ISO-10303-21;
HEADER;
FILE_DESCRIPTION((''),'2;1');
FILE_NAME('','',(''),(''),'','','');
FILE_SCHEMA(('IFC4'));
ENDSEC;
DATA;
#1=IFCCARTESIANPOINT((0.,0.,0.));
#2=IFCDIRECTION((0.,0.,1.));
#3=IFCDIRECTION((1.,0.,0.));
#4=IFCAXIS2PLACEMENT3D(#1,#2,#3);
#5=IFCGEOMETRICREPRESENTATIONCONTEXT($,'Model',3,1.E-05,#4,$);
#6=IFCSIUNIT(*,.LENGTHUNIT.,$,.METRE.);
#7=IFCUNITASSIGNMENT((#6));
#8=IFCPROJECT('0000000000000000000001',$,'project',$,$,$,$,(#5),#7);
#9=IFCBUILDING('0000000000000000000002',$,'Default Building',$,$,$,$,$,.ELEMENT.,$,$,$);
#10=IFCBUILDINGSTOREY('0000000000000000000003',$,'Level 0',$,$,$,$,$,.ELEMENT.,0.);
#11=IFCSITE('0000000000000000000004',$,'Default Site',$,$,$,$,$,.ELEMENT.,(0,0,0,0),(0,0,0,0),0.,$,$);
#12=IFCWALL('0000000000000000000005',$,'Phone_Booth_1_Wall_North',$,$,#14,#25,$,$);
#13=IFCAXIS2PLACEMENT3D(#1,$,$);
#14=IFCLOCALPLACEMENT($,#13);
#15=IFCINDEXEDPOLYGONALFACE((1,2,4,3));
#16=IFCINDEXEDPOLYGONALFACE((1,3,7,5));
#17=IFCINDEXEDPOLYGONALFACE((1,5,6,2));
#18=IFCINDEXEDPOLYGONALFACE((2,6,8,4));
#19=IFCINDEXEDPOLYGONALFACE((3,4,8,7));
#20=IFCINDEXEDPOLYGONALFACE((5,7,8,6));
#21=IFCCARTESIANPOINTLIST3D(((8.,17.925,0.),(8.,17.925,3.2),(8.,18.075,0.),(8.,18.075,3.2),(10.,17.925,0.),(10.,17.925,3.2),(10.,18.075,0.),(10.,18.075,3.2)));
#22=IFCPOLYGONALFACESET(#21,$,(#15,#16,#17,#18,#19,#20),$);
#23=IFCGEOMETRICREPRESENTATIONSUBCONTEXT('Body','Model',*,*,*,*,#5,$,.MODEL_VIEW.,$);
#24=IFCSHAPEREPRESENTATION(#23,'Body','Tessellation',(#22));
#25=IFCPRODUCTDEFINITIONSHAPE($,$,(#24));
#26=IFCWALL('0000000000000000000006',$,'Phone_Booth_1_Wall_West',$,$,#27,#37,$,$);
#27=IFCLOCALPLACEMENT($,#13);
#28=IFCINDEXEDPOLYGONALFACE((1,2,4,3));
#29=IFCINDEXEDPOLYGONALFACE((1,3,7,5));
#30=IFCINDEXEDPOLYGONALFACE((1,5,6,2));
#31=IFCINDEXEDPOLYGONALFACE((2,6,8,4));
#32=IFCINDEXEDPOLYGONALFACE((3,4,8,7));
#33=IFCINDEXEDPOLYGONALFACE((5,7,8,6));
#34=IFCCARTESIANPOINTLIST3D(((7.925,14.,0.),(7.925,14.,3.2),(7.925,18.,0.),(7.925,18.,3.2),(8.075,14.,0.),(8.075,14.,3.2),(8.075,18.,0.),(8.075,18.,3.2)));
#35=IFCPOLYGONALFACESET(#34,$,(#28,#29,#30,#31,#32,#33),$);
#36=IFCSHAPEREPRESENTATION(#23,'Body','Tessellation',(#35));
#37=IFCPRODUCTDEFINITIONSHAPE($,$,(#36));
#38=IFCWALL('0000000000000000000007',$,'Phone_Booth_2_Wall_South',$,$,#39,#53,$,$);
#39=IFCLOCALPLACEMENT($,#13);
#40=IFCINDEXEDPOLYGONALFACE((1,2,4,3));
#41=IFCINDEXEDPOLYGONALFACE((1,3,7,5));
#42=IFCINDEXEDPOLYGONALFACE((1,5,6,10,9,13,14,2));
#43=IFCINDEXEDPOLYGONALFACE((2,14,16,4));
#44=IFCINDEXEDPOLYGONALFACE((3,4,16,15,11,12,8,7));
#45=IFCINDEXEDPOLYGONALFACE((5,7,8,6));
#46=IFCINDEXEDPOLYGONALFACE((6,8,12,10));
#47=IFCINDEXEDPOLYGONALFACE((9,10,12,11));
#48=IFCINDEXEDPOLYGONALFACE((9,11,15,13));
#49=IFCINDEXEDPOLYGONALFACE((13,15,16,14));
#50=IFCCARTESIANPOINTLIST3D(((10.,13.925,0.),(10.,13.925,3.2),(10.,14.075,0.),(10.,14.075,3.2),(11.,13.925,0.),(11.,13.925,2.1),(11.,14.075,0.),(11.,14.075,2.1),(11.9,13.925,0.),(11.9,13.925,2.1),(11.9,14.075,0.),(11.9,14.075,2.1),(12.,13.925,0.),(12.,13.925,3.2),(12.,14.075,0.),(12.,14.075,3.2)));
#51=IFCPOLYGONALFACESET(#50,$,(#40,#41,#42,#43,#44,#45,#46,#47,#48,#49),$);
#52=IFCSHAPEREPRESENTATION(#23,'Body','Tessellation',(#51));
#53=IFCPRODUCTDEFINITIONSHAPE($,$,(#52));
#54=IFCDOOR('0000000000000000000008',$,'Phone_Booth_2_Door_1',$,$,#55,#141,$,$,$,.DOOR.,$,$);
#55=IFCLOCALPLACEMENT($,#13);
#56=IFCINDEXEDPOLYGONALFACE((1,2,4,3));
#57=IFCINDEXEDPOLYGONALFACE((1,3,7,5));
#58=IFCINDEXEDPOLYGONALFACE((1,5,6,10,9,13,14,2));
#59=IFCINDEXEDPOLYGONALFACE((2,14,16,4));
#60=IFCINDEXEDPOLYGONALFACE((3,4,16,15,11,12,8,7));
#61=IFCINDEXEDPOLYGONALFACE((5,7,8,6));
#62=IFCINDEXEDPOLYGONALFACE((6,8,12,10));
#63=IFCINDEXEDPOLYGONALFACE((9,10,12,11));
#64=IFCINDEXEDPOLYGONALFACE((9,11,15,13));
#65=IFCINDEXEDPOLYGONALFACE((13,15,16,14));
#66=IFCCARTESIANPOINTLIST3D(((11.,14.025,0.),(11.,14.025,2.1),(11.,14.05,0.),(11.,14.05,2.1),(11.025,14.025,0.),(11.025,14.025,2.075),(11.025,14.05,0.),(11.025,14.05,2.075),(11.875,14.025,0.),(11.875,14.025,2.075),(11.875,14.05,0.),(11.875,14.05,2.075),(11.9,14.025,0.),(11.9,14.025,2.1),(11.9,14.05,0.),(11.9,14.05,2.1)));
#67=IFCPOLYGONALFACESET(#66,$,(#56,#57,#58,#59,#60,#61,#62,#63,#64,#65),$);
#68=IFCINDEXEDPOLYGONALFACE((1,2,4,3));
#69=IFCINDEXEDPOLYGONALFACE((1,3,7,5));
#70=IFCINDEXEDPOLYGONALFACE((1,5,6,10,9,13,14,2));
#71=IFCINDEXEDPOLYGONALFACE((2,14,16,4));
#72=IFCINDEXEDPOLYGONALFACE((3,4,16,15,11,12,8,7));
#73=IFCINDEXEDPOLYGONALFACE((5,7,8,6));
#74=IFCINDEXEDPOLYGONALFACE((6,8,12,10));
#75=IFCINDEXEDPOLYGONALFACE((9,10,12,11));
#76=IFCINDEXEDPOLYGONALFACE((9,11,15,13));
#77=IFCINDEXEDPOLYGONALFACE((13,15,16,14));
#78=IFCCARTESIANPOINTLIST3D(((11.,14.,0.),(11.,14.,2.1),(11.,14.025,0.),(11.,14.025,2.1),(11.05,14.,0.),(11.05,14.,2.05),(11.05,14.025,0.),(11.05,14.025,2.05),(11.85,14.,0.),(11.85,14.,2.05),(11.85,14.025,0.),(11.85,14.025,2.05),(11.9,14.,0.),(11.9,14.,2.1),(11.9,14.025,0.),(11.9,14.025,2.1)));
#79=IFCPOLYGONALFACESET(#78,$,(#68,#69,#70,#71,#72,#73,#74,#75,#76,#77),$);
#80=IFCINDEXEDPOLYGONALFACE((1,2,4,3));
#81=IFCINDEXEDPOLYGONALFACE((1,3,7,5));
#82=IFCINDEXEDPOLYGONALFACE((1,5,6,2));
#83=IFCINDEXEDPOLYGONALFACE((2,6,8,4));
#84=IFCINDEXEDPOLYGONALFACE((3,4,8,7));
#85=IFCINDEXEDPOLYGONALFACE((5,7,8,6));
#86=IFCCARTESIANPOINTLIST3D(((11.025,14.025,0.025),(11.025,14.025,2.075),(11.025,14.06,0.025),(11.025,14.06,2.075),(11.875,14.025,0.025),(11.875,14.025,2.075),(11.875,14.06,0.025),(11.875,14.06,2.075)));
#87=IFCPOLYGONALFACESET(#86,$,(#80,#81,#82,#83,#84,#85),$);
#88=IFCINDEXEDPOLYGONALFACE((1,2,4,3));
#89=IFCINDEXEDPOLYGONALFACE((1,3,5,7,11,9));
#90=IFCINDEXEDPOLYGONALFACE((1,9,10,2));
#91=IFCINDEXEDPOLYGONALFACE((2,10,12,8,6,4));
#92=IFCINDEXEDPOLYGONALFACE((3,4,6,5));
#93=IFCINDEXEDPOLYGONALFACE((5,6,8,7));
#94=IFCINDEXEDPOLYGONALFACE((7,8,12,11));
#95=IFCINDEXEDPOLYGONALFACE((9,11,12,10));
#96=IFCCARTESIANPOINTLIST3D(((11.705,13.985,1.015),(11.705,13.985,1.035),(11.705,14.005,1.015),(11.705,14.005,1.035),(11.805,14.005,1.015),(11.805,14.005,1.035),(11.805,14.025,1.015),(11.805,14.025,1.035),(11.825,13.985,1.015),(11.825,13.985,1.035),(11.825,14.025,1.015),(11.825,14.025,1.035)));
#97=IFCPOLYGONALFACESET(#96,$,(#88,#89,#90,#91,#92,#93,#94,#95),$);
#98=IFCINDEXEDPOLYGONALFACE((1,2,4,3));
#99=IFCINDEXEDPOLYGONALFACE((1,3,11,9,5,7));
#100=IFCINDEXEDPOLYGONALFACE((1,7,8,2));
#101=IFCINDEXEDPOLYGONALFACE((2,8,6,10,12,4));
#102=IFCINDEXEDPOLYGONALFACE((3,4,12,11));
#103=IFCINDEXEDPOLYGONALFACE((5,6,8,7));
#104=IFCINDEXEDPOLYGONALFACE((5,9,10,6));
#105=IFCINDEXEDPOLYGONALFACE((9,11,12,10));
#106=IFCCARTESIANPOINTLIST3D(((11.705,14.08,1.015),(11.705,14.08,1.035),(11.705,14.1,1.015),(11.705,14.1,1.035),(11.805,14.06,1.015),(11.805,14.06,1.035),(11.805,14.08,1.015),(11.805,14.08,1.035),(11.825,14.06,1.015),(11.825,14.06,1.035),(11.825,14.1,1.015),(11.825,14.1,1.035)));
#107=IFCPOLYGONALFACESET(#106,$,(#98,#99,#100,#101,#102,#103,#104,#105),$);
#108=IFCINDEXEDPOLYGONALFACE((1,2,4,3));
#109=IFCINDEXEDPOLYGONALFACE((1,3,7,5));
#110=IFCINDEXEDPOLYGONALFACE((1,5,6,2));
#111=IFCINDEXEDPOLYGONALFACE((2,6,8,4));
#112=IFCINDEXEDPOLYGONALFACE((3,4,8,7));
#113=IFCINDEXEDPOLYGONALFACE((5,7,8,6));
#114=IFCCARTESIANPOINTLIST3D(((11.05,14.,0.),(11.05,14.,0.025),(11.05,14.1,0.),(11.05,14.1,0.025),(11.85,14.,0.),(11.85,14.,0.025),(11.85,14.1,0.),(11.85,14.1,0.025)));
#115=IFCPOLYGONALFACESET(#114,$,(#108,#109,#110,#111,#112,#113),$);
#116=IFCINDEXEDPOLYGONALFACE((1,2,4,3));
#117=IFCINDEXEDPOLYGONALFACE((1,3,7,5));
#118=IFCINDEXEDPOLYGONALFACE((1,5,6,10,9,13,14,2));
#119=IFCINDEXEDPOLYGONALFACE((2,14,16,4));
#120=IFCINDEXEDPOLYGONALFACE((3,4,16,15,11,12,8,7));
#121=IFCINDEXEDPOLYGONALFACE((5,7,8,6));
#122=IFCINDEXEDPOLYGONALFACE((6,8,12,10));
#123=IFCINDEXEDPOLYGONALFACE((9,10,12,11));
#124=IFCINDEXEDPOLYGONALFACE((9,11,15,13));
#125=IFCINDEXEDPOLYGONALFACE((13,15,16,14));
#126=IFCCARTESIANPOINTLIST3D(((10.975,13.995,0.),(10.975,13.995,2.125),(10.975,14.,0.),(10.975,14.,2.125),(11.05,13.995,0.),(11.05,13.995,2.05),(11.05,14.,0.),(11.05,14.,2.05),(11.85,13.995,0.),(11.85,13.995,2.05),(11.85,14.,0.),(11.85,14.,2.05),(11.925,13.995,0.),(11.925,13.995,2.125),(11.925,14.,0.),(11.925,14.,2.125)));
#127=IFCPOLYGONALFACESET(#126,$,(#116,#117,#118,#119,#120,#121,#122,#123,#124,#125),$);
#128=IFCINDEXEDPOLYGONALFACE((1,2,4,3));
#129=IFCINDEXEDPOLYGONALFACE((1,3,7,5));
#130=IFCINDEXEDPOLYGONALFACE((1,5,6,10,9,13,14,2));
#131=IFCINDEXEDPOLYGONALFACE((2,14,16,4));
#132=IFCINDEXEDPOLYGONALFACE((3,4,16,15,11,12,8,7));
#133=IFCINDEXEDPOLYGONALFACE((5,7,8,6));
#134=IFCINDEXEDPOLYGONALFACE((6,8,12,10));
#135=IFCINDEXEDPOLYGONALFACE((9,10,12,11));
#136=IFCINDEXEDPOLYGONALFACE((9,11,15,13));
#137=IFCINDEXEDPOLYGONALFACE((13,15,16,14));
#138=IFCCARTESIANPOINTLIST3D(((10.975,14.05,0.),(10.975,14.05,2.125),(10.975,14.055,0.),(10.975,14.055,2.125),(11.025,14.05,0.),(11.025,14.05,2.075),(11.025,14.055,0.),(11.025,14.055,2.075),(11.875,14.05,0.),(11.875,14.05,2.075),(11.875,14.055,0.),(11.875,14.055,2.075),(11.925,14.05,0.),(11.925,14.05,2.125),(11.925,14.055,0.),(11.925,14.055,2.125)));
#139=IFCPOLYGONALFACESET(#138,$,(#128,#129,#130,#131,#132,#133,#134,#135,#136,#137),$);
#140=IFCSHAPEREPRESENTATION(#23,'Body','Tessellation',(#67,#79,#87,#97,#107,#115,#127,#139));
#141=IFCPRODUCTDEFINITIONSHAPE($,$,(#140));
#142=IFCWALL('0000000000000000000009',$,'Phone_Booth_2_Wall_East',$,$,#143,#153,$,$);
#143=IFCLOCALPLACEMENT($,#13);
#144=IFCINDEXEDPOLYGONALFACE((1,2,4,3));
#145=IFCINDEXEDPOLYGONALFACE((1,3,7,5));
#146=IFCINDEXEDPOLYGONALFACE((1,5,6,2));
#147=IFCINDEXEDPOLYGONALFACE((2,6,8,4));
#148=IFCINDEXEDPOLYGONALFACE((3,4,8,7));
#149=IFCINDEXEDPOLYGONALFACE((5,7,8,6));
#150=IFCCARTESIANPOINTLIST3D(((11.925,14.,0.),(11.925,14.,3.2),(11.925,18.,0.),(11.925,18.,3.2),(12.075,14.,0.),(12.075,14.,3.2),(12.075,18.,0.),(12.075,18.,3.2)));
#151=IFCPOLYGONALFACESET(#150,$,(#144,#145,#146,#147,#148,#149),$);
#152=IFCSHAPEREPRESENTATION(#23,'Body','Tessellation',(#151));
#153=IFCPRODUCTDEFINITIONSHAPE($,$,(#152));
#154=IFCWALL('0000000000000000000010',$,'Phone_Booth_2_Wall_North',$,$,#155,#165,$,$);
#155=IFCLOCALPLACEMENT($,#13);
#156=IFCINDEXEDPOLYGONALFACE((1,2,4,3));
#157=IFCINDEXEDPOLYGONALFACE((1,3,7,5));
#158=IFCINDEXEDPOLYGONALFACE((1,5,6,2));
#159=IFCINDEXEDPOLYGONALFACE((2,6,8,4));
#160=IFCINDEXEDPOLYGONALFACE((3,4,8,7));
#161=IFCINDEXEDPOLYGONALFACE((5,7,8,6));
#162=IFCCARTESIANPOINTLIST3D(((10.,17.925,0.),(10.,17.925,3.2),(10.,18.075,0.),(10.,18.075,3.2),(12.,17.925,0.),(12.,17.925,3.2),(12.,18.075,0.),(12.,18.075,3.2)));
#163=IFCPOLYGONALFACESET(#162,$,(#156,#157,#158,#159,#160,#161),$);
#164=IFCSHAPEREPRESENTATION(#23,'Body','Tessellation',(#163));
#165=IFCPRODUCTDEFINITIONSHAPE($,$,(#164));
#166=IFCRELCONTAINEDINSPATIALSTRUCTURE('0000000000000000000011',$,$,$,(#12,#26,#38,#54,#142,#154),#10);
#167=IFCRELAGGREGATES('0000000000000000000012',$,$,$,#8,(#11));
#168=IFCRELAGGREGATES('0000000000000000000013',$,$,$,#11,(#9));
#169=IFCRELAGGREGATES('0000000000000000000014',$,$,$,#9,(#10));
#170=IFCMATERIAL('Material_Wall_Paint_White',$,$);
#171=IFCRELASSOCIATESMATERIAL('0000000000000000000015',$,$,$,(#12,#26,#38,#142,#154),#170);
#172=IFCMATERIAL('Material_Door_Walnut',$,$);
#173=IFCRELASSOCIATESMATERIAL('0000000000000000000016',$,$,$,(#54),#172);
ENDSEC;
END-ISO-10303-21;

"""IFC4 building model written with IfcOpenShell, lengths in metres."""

from ifc_helpers import new_model, si_unit, frame, origin_with_axes, place, context, subcontext, project, spatial, line, indexed_curve, outline, extrude, material, element, fill, save


model = new_model("IFC4")

# Units and contexts
model_context = context("Model", 3, precision=1e-05, world=origin_with_axes())
body_context = subcontext(model_context, "Body", "Model", "MODEL_VIEW")
ifc_project = project(units=[si_unit("LENGTHUNIT", "METRE")], contexts=[model_context])

# Site, building, storey
site = spatial("IfcSite", under=ifc_project, Name="Default Site", CompositionType="ELEMENT", RefLatitude=(0, 0, 0, 0), RefLongitude=(0, 0, 0, 0), RefElevation=0.0)
building = spatial("IfcBuilding", under=site, Name="Default Building", CompositionType="ELEMENT")
storey = spatial("IfcBuildingStorey", under=building, Name="Level 0", CompositionType="ELEMENT", Elevation=0.0)

# Shared definitions
ifc_material_1 = material(Name="Material_Wall_Paint_White")

# Shared definitions
ifc_material_2 = material(Name="Material_Door_Walnut")

# Walls
wall_1_placement = place(None, frame((10.0, 18.0, 0.0), z_axis=(0.0, 0.0, 1.0), x_axis=(-1.0, 0.0, 0.0)))
element("IfcWall", 1, at=wall_1_placement, inside=storey, material=ifc_material_1, Name="Phone_Booth_1_Wall_North", context=body_context, shape_type="SweptSolid", body=[
    extrude(outline(indexed_curve([(0.0, 0.0), (0.0, 0.15), (2.0, 0.15), (2.0, 0.0), (0.0, 0.0)], self_intersect=False)), frame((0.0, -0.075, 0.0), z_axis=(0.0, 0.0, 1.0), x_axis=(1.0, 0.0, 0.0)), (0.0, 0.0, 1.0), 3.2),
])
wall_2_placement = place(None, frame((8.0, 18.0, 0.0), z_axis=(0.0, 0.0, 1.0), x_axis=(0.0, -1.0, 0.0)))
element("IfcWall", 2, at=wall_2_placement, inside=storey, material=ifc_material_1, Name="Phone_Booth_1_Wall_West", context=body_context, shape_type="SweptSolid", body=[
    extrude(outline(indexed_curve([(0.0, 0.0), (0.0, 0.15), (4.0, 0.15), (4.0, 0.0), (0.0, 0.0)], self_intersect=False)), frame((0.0, -0.075, 0.0), z_axis=(0.0, 0.0, 1.0), x_axis=(1.0, 0.0, 0.0)), (0.0, 0.0, 1.0), 3.2),
])

# Wall, opening, door
wall_3_placement = place(None, frame((10.0, 14.0, 0.0), z_axis=(0.0, 0.0, 1.0), x_axis=(1.0, 0.0, 0.0)))
wall_3 = element("IfcWall", 3, at=wall_3_placement, inside=storey, material=ifc_material_1, Name="Phone_Booth_2_Wall_South", context=body_context, shape_type="SweptSolid", body=[
    extrude(outline(indexed_curve([(0.0, 0.0), (0.0, 0.15), (2.0, 0.15), (2.0, 0.0), (0.0, 0.0)], self_intersect=False)), frame((0.0, -0.075, 0.0), z_axis=(0.0, 0.0, 1.0), x_axis=(1.0, 0.0, 0.0)), (0.0, 0.0, 1.0), 3.2),
])
opening_1_placement = place(wall_3_placement, frame((1.0, -0.5, 0.0), z_axis=(0.0, 0.0, 1.0), x_axis=(1.0, 0.0, 0.0)))
opening_1 = element("IfcOpeningElement", 4, at=opening_1_placement, inside=storey, cuts=wall_3, PredefinedType="OPENING", context=body_context, shape_type="SweptSolid", body=[
    extrude(outline(indexed_curve([(0.0, 0.0), (0.0, 1.0), (0.9, 1.0), (0.9, 0.0), (0.0, 0.0)], self_intersect=False)), origin_with_axes(), (0.0, 0.0, 1.0), 2.1),
])
door_1_placement = place(None, frame((11.0, 14.0, 0.0), z_axis=(0.0, 0.0, 1.0), x_axis=(1.0, 0.0, 0.0)))
door_1 = element("IfcDoor", 5, at=door_1_placement, inside=storey, material=ifc_material_2, Name="Phone_Booth_2_Door_1", PredefinedType="DOOR", context=body_context, shape_type="SweptSolid", body=[
    extrude(outline(indexed_curve([(0.0, 0.0), (0.0, 2.1), (0.9, 2.1), (0.9, 0.0), (0.875, 0.0), (0.875, 2.075), (0.025, 2.075), (0.025, 0.0)], segments=[line(1, 2, 3, 4, 5, 6, 7, 8, 1)])), frame((0.0, 0.025, 0.0), z_axis=(0.0, -1.0, 0.0), x_axis=(1.0, 0.0, 0.0)), (0.0, 0.0, -1.0), 0.025),
    extrude(outline(indexed_curve([(0.0, 0.0), (0.0, 2.1), (0.9, 2.1), (0.9, 0.0), (0.85, 0.0), (0.85, 2.05), (0.05, 2.05), (0.05, 0.0)], segments=[line(1, 2, 3, 4, 5, 6, 7, 8, 1)])), frame((0.0, 0.0, 0.0), z_axis=(0.0, -1.0, 0.0), x_axis=(1.0, 0.0, 0.0)), (0.0, 0.0, -1.0), 0.025),
    extrude(outline(indexed_curve([(0.0, 0.0), (0.85, 0.0), (0.85, 0.035), (0.0, 0.035)], segments=[line(1, 2, 3, 4, 1)])), frame((0.025, 0.025, 0.025), z_axis=(0.0, 0.0, 1.0), x_axis=(1.0, 0.0, 0.0)), (0.0, 0.0, 1.0), 2.05),
    extrude(outline(indexed_curve([(0.0, 0.0), (0.0, -0.04), (-0.12, -0.04), (-0.12, -0.02), (-0.02, -0.02), (-0.02, 0.0)], segments=[line(1, 2, 3, 4, 5, 6, 1)])), frame((0.825, 0.025, 1.015), z_axis=(0.0, 0.0, 1.0), x_axis=(1.0, 0.0, 0.0)), (0.0, 0.0, 1.0), 0.02),
    extrude(outline(indexed_curve([(0.0, 0.0), (0.0, 0.04), (-0.12, 0.04), (-0.12, 0.02), (-0.02, 0.02), (-0.02, 0.0)], segments=[line(1, 2, 3, 4, 5, 6, 1)])), frame((0.825, 0.06, 1.015), z_axis=(0.0, 0.0, 1.0), x_axis=(1.0, 0.0, 0.0)), (0.0, 0.0, 1.0), 0.02),
    extrude(outline(indexed_curve([(0.0, 0.0), (0.8, 0.0), (0.8, 0.1), (0.0, 0.1)], segments=[line(1, 2, 3, 4, 1)])), frame((0.05, 0.0, 0.0), z_axis=(0.0, 0.0, 1.0), x_axis=(1.0, 0.0, 0.0)), (0.0, 0.0, 1.0), 0.025),
    extrude(outline(indexed_curve([(0.0, 0.0), (0.0, 2.125), (0.95, 2.125), (0.95, 0.0), (0.875, 0.0), (0.875, 2.05), (0.075, 2.05), (0.075, 0.0)], segments=[line(1, 2, 3, 4, 5, 6, 7, 8, 1)])), frame((-0.025, -0.005, 0.0), z_axis=(0.0, -1.0, 0.0), x_axis=(1.0, 0.0, 0.0)), (0.0, 0.0, -1.0), 0.005),
    extrude(outline(indexed_curve([(0.0, 0.0), (0.0, 2.125), (0.95, 2.125), (0.95, 0.0), (0.9, 0.0), (0.9, 2.075), (0.05, 2.075), (0.05, 0.0)], segments=[line(1, 2, 3, 4, 5, 6, 7, 8, 1)])), frame((-0.025, 0.05, 0.0), z_axis=(0.0, -1.0, 0.0), x_axis=(1.0, 0.0, 0.0)), (0.0, 0.0, -1.0), 0.005),
])
fill(opening_1, door_1)

# Walls
wall_4_placement = place(None, frame((12.0, 14.0, 0.0), z_axis=(0.0, 0.0, 1.0), x_axis=(0.0, 1.0, 0.0)))
element("IfcWall", 6, at=wall_4_placement, inside=storey, material=ifc_material_1, Name="Phone_Booth_2_Wall_East", context=body_context, shape_type="SweptSolid", body=[
    extrude(outline(indexed_curve([(0.0, 0.0), (0.0, 0.15), (4.0, 0.15), (4.0, 0.0), (0.0, 0.0)], self_intersect=False)), frame((0.0, -0.075, 0.0), z_axis=(0.0, 0.0, 1.0), x_axis=(1.0, 0.0, 0.0)), (0.0, 0.0, 1.0), 3.2),
])
wall_5_placement = place(None, frame((12.0, 18.0, 0.0), z_axis=(0.0, 0.0, 1.0), x_axis=(-1.0, 0.0, 0.0)))
element("IfcWall", 7, at=wall_5_placement, inside=storey, material=ifc_material_1, Name="Phone_Booth_2_Wall_North", context=body_context, shape_type="SweptSolid", body=[
    extrude(outline(indexed_curve([(0.0, 0.0), (0.0, 0.15), (2.0, 0.15), (2.0, 0.0), (0.0, 0.0)], self_intersect=False)), frame((0.0, -0.075, 0.0), z_axis=(0.0, 0.0, 1.0), x_axis=(1.0, 0.0, 0.0)), (0.0, 0.0, 1.0), 3.2),
])

save(model, "model.ifc")
